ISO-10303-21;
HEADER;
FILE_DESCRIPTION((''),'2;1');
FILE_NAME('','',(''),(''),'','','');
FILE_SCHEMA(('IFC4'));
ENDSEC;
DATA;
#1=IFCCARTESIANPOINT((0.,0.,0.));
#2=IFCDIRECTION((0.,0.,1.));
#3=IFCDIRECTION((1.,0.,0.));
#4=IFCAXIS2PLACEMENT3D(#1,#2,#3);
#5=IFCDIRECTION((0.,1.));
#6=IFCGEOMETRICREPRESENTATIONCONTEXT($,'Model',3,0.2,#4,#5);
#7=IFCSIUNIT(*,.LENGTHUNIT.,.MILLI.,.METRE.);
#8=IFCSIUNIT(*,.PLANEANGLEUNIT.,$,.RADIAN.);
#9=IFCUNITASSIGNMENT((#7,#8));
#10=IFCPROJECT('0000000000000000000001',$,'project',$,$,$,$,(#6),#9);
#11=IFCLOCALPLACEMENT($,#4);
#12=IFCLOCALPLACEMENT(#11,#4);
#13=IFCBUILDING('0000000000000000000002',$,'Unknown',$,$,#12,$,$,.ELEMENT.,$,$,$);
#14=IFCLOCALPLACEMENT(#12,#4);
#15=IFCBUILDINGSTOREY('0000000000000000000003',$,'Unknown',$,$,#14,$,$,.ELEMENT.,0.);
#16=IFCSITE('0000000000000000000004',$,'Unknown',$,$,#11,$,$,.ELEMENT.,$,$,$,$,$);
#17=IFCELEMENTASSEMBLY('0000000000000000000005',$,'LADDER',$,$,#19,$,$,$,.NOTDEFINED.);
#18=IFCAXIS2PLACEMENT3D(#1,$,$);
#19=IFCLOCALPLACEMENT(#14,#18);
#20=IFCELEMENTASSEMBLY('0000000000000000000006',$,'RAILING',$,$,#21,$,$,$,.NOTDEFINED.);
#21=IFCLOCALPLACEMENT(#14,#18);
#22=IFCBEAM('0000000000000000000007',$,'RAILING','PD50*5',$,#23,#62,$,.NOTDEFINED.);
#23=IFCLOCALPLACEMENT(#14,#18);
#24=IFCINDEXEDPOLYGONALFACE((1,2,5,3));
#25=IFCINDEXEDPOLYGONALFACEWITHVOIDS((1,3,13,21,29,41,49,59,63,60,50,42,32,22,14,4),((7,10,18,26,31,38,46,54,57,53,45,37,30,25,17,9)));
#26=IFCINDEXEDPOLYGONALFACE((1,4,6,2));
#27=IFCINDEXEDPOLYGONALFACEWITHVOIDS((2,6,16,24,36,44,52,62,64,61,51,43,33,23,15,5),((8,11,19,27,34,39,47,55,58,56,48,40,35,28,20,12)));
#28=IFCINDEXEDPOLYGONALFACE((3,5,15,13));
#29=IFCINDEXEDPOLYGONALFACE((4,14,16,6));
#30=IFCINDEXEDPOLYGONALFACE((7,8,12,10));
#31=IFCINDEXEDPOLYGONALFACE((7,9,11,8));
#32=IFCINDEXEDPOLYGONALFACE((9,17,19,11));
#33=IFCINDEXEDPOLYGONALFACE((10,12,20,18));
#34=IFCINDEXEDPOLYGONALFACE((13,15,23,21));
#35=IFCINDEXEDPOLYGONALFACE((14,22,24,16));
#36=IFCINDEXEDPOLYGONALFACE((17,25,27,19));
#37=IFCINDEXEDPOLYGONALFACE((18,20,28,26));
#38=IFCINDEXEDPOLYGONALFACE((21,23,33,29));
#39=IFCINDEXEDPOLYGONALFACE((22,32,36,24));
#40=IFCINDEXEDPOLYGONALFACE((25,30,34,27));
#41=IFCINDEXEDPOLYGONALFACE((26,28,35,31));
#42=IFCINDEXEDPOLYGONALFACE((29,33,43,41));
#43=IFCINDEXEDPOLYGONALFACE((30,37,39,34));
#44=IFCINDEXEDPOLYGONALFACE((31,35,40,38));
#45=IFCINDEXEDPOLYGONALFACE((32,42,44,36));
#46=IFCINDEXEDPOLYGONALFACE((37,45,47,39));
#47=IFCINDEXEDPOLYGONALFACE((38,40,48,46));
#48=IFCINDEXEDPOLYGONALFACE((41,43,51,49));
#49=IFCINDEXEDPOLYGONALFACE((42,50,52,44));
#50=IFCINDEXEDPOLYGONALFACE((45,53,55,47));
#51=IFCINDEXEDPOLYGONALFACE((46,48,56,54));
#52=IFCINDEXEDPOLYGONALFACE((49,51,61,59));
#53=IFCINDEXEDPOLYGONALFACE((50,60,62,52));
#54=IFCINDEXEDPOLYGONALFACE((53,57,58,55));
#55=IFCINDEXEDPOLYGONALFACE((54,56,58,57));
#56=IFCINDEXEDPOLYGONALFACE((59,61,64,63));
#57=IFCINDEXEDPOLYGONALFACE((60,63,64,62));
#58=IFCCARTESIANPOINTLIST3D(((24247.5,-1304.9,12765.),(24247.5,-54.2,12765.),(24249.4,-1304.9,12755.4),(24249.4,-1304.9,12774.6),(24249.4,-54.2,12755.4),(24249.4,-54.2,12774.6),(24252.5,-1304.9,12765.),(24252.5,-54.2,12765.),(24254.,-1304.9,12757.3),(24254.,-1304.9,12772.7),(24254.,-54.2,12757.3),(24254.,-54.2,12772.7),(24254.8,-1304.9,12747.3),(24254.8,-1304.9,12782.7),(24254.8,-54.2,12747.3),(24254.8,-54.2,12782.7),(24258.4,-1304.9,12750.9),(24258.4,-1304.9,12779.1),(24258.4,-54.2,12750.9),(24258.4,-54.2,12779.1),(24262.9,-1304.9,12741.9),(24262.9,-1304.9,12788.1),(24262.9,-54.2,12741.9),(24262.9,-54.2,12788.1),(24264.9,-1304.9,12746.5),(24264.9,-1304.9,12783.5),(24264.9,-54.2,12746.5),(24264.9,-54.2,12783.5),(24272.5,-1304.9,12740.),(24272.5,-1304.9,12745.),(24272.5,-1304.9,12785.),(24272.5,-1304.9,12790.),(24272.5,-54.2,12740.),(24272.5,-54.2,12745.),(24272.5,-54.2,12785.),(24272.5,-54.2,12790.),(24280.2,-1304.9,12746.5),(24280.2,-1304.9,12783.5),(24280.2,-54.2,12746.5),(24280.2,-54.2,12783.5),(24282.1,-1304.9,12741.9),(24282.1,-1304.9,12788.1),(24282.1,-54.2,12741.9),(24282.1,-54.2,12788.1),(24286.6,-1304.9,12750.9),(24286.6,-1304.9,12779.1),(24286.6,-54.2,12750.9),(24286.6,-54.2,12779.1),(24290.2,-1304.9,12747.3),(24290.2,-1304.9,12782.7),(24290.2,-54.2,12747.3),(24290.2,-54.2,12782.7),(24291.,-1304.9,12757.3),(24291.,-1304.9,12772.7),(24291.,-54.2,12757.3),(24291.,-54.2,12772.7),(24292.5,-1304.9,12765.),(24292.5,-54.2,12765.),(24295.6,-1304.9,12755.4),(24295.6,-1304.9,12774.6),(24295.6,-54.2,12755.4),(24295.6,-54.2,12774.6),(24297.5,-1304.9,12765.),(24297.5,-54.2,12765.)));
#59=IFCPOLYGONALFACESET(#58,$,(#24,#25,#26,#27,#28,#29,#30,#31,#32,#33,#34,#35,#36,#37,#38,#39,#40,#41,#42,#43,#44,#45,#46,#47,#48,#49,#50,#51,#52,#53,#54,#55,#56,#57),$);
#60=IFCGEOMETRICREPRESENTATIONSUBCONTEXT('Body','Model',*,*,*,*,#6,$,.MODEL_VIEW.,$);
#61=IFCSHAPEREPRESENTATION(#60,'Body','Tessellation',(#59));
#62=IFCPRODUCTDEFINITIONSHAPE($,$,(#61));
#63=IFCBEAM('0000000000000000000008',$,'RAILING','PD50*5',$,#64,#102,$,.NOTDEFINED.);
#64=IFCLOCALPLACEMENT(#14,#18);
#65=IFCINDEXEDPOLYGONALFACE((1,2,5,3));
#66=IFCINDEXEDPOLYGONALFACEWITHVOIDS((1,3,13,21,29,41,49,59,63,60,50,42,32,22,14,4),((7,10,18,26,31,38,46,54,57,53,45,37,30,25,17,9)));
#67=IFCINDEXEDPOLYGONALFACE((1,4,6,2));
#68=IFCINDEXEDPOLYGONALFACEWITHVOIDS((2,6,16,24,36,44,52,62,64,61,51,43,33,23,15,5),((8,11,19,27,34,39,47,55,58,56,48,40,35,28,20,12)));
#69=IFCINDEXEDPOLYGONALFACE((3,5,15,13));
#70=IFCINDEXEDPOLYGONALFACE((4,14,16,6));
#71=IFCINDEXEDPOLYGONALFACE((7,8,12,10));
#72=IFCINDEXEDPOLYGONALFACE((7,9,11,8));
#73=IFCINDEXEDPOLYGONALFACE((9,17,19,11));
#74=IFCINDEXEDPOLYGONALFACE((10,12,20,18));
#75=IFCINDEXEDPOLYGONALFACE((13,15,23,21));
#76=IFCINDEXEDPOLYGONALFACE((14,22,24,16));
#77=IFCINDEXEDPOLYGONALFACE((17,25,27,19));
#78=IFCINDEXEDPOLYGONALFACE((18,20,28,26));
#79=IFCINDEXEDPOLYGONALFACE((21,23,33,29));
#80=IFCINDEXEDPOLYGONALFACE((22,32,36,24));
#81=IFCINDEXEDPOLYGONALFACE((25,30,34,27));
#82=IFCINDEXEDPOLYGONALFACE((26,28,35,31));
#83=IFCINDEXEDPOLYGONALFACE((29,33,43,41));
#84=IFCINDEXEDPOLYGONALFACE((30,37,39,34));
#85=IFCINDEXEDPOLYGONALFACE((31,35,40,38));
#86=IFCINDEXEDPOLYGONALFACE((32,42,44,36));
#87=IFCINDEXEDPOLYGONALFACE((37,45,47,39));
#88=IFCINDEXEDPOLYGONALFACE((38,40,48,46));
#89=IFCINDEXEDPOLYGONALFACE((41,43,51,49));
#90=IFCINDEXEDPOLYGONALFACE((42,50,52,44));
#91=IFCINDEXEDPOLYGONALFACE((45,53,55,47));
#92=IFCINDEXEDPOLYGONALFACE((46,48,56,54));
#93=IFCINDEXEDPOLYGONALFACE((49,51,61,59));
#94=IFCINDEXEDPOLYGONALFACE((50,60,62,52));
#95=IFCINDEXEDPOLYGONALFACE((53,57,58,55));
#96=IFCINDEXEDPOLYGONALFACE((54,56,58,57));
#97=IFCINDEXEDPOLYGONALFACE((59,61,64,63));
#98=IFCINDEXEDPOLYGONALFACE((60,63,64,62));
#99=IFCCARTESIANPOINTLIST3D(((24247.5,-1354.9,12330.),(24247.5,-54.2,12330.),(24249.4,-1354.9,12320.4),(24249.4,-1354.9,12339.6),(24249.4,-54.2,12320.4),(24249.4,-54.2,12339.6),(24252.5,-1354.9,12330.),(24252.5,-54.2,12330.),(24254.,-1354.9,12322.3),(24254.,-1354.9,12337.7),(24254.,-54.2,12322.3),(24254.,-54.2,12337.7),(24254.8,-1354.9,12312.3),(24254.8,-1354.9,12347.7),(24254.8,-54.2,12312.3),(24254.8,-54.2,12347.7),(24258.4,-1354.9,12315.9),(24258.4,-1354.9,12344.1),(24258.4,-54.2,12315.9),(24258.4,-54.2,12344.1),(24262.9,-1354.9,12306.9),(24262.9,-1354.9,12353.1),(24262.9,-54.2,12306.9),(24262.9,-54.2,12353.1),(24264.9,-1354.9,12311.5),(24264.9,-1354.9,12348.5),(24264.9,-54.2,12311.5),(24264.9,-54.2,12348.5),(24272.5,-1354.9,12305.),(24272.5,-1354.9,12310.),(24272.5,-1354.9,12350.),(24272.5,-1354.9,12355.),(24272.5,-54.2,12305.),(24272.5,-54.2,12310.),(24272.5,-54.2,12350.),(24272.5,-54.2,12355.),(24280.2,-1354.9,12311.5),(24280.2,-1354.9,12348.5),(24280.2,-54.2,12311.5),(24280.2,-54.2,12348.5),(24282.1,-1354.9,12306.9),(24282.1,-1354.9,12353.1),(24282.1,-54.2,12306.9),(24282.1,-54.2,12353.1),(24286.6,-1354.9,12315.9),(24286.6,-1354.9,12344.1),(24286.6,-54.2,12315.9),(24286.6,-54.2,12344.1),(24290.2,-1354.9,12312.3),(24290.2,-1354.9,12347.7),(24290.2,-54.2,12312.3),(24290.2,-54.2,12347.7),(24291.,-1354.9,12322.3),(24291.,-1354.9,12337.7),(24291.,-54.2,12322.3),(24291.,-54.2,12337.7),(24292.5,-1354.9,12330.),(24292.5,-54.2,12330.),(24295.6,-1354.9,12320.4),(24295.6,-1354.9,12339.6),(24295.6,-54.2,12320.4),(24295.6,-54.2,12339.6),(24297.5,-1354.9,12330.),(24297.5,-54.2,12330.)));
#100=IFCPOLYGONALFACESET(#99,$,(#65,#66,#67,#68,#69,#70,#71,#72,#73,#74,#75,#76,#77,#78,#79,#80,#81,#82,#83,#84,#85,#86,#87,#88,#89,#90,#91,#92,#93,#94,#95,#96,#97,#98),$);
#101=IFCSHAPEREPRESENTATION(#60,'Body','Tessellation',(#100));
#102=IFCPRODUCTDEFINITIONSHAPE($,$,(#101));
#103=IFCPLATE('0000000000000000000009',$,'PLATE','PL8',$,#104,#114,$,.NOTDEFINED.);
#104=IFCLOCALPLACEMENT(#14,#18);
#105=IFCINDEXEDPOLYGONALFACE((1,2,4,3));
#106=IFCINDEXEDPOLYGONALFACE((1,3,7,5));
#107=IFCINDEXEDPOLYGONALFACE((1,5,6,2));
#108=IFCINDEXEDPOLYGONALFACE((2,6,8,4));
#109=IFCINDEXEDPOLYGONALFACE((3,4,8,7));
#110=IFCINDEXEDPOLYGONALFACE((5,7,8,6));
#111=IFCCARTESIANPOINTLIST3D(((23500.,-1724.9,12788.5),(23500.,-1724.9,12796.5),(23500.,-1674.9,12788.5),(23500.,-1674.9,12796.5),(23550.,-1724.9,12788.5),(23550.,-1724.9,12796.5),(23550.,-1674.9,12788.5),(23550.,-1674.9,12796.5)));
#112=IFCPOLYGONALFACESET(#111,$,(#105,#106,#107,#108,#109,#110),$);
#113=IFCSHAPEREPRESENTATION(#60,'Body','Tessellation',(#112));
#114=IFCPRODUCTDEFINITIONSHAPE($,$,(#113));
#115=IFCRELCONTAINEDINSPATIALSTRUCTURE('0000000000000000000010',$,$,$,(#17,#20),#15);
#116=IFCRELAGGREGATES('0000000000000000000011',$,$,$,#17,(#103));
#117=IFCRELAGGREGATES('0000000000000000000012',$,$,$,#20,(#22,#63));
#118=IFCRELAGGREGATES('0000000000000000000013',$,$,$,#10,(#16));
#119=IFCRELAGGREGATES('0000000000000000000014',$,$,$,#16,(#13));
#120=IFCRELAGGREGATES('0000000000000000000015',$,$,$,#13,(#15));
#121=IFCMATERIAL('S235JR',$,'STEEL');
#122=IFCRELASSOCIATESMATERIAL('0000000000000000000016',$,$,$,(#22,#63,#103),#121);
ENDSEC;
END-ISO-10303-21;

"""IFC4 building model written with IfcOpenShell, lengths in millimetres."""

from ifc_helpers import new_model, si_unit, direction, frame, origin_with_axes, place, context, subcontext, project, spatial, line, indexed_curve, outline, extrude, material, element, aggregate, save


model = new_model("IFC4")

# Units and contexts
model_context = context("Model", 3, precision=0.2, world=origin_with_axes(), true_north=direction((0.0, 1.0)))
body_context = subcontext(model_context, "Body", "Model", "MODEL_VIEW")
ifc_project = project(units=[si_unit("LENGTHUNIT", "METRE", prefix="MILLI"), si_unit("PLANEANGLEUNIT", "RADIAN")], contexts=[model_context])

# Site, building, storey
site_placement = place(None, origin_with_axes())
site = spatial("IfcSite", under=ifc_project, at=site_placement, Name="Unknown", CompositionType="ELEMENT")
building_placement = place(site_placement, origin_with_axes())
building = spatial("IfcBuilding", under=site, at=building_placement, Name="Unknown", CompositionType="ELEMENT")
storey_placement = place(building_placement, origin_with_axes())
storey = spatial("IfcBuildingStorey", under=building, at=storey_placement, Name="Unknown", CompositionType="ELEMENT", Elevation=0.0)

# Element assembly
assembly_1_placement = place(storey_placement, frame((23525.0, -1699.9, 5175.0), z_axis=(0.0, 1.0, 0.0), x_axis=(0.0, 0.0, 1.0)))
assembly_1 = element("IfcElementAssembly", 1, at=assembly_1_placement, inside=storey, Name="LADDER", PredefinedType="NOTDEFINED")
ifc_material_1 = material(Name="S235JR", Category="STEEL")

# Element assembly, beams
assembly_2_placement = place(storey_placement, frame((24272.5, -1304.9, 12765.0), z_axis=(-1.0, 0.0, 0.0), x_axis=(0.0, 1.0, 0.0)))
assembly_2 = element("IfcElementAssembly", 2, at=assembly_2_placement, inside=storey, Name="RAILING", PredefinedType="NOTDEFINED")
beam_1_placement = place(assembly_2_placement, origin_with_axes())
beam_1 = element("IfcBeam", 3, at=beam_1_placement, material=ifc_material_1, Name="RAILING", Description="PD50*5", PredefinedType="NOTDEFINED", context=body_context, shape_type="SolidModel", body=[
    extrude(outline(indexed_curve([(25.0, 0.0), (23.1, 9.6), (17.7, 17.7), (9.6, 23.1), (0.0, 25.0), (-9.6, 23.1), (-17.7, 17.7), (-23.1, 9.6), (-25.0, 0.0), (-23.1, -9.6), (-17.7, -17.7), (-9.6, -23.1), (0.0, -25.0), (9.6, -23.1), (17.7, -17.7), (23.1, -9.6)], segments=[line(1, 2, 3, 4, 5, 6, 7, 8, 9, 10, 11, 12, 13, 14, 15, 16, 1)]), holes=[indexed_curve([(20.0, 0.0), (18.5, -7.7), (14.1, -14.1), (7.7, -18.5), (0.0, -20.0), (-7.7, -18.5), (-14.1, -14.1), (-18.5, -7.7), (-20.0, 0.0), (-18.5, 7.7), (-14.1, 14.1), (-7.7, 18.5), (0.0, 20.0), (7.7, 18.5), (14.1, 14.1), (18.5, 7.7)], segments=[line(1, 2, 3, 4, 5, 6, 7, 8, 9, 10, 11, 12, 13, 14, 15, 16, 1)])]), frame((0.0, 0.0, 0.0), z_axis=(-1.0, 0.0, 0.0), x_axis=(0.0, 0.0, 1.0)), (0.0, 0.0, -1.0), 1250.8),
])
beam_2_placement = place(assembly_2_placement, frame((-50.0, 435.0, 0.0), z_axis=(0.0, -1.0, 0.0), x_axis=(1.0, 0.0, 0.0)))
beam_2 = element("IfcBeam", 4, at=beam_2_placement, material=ifc_material_1, Name="RAILING", Description="PD50*5", PredefinedType="NOTDEFINED", context=body_context, shape_type="SolidModel", body=[
    extrude(outline(indexed_curve([(25.0, 0.0), (23.1, 9.6), (17.7, 17.7), (9.6, 23.1), (0.0, 25.0), (-9.6, 23.1), (-17.7, 17.7), (-23.1, 9.6), (-25.0, 0.0), (-23.1, -9.6), (-17.7, -17.7), (-9.6, -23.1), (0.0, -25.0), (9.6, -23.1), (17.7, -17.7), (23.1, -9.6)], segments=[line(1, 2, 3, 4, 5, 6, 7, 8, 9, 10, 11, 12, 13, 14, 15, 16, 1)]), holes=[indexed_curve([(20.0, 0.0), (18.5, -7.7), (14.1, -14.1), (7.7, -18.5), (0.0, -20.0), (-7.7, -18.5), (-14.1, -14.1), (-18.5, -7.7), (-20.0, 0.0), (-18.5, 7.7), (-14.1, 14.1), (-7.7, 18.5), (0.0, 20.0), (7.7, 18.5), (14.1, 14.1), (18.5, 7.7)], segments=[line(1, 2, 3, 4, 5, 6, 7, 8, 9, 10, 11, 12, 13, 14, 15, 16, 1)])]), frame((0.0, 0.0, 0.0), z_axis=(-1.0, 0.0, 0.0), x_axis=(0.0, 0.0, 1.0)), (0.0, 0.0, -1.0), 1300.8),
])

# Plate
plate_1_placement = place(assembly_1_placement, frame((7617.5, 25.0, 25.0), z_axis=(1.0, 0.0, 0.0), x_axis=(0.0, -1.0, 0.0)))
plate_1 = element("IfcPlate", 5, at=plate_1_placement, material=ifc_material_1, Name="PLATE", Description="PL8", PredefinedType="NOTDEFINED", context=body_context, shape_type="SolidModel", body=[
    extrude(outline(indexed_curve([(0.0, 0.0), (50.0, 0.0), (50.0, 50.0), (0.0, 50.0)], segments=[line(1, 2, 3, 4, 1)])), frame((0.0, 0.0, 4.0), z_axis=(0.0, 0.0, 1.0), x_axis=(1.0, 0.0, 0.0)), (0.0, 0.0, -1.0), 8.0),
])
aggregate(assembly_1, [plate_1])
aggregate(assembly_2, [beam_1, beam_2])

save(model, "model.ifc")
